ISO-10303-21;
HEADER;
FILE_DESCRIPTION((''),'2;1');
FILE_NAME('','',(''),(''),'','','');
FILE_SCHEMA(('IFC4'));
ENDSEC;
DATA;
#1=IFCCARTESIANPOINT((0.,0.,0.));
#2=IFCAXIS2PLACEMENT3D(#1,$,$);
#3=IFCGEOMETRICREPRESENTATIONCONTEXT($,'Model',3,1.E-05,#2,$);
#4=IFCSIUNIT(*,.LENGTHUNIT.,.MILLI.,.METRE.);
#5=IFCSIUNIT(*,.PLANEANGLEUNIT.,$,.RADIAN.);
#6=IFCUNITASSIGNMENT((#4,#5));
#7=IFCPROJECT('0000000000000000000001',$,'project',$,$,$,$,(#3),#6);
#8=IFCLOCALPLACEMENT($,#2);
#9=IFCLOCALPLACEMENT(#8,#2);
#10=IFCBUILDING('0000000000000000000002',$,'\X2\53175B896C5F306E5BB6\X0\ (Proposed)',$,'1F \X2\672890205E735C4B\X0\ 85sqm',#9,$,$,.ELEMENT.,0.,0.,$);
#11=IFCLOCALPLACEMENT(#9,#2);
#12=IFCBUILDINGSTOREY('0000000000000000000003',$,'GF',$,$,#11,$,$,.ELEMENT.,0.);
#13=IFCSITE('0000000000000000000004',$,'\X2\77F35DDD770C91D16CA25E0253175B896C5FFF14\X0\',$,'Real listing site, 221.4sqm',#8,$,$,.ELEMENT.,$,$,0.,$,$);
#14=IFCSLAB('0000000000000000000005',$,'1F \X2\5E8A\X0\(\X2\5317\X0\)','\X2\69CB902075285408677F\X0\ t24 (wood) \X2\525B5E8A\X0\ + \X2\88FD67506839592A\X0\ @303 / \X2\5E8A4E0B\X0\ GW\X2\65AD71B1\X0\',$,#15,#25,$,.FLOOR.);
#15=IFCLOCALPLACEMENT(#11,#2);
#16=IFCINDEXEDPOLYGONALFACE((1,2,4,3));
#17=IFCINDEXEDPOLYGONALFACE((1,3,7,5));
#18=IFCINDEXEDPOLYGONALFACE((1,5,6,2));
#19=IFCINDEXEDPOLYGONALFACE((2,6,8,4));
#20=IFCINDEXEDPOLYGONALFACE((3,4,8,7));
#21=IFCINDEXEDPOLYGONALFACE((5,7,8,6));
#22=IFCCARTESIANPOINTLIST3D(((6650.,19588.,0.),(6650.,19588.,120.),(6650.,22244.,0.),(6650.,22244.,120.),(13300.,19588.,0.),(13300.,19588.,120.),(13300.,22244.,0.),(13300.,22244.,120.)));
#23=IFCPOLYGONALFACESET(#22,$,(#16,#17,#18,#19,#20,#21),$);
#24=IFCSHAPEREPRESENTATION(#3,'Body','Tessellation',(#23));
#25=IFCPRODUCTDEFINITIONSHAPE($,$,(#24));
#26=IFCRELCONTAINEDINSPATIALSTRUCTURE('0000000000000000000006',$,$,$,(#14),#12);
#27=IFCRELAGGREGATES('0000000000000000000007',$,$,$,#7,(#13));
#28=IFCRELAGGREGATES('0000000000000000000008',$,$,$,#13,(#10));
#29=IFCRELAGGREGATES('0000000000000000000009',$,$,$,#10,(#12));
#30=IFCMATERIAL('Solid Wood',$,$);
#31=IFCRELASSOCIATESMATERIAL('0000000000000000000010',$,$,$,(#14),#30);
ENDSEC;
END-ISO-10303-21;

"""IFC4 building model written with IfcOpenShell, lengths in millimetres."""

from ifc_helpers import new_model, si_unit, frame, frame_2d, origin, place, context, project, spatial, rectangle, extrude, material, element, save


model = new_model("IFC4")

# Units and contexts
model_context = context("Model", 3, precision=1e-05, world=origin())
ifc_project = project(units=[si_unit("LENGTHUNIT", "METRE", prefix="MILLI"), si_unit("PLANEANGLEUNIT", "RADIAN")], contexts=[model_context])

# Site, building, storey
site_placement = place(None, origin())
site = spatial("IfcSite", under=ifc_project, at=site_placement, Name="石川県金沢市北安江４", ObjectType="Real listing site, 221.4sqm", CompositionType="ELEMENT", RefElevation=0.0)
building_placement = place(site_placement, origin())
building = spatial("IfcBuilding", under=site, at=building_placement, Name="北安江の家 (Proposed)", ObjectType="1F 木造平屋 85sqm", CompositionType="ELEMENT", ElevationOfRefHeight=0.0, ElevationOfTerrain=0.0)
storey_placement = place(building_placement, origin())
storey = spatial("IfcBuildingStorey", under=building, at=storey_placement, Name="GF", CompositionType="ELEMENT", Elevation=0.0)

# Slab
ifc_material_1 = material(Name="Solid Wood")
slab_1_placement = place(storey_placement, frame((3325.0, 9794.0, 0.0)))
element("IfcSlab", 1, at=slab_1_placement, inside=storey, material=ifc_material_1, Name="1F 床(北)", Description="構造用合板 t24 (wood) 剛床 + 製材根太 @303 / 床下 GW断熱", PredefinedType="FLOOR", context=model_context, shape_type="SweptSolid", body=[
    extrude(rectangle(XDim=6650.0, YDim=2656.0, at=frame_2d((3325.0, 1328.0))), frame((3325.0, 9794.0, 0.0)), (0.0, 0.0, 1.0), 120.0),
])

save(model, "model.ifc")
